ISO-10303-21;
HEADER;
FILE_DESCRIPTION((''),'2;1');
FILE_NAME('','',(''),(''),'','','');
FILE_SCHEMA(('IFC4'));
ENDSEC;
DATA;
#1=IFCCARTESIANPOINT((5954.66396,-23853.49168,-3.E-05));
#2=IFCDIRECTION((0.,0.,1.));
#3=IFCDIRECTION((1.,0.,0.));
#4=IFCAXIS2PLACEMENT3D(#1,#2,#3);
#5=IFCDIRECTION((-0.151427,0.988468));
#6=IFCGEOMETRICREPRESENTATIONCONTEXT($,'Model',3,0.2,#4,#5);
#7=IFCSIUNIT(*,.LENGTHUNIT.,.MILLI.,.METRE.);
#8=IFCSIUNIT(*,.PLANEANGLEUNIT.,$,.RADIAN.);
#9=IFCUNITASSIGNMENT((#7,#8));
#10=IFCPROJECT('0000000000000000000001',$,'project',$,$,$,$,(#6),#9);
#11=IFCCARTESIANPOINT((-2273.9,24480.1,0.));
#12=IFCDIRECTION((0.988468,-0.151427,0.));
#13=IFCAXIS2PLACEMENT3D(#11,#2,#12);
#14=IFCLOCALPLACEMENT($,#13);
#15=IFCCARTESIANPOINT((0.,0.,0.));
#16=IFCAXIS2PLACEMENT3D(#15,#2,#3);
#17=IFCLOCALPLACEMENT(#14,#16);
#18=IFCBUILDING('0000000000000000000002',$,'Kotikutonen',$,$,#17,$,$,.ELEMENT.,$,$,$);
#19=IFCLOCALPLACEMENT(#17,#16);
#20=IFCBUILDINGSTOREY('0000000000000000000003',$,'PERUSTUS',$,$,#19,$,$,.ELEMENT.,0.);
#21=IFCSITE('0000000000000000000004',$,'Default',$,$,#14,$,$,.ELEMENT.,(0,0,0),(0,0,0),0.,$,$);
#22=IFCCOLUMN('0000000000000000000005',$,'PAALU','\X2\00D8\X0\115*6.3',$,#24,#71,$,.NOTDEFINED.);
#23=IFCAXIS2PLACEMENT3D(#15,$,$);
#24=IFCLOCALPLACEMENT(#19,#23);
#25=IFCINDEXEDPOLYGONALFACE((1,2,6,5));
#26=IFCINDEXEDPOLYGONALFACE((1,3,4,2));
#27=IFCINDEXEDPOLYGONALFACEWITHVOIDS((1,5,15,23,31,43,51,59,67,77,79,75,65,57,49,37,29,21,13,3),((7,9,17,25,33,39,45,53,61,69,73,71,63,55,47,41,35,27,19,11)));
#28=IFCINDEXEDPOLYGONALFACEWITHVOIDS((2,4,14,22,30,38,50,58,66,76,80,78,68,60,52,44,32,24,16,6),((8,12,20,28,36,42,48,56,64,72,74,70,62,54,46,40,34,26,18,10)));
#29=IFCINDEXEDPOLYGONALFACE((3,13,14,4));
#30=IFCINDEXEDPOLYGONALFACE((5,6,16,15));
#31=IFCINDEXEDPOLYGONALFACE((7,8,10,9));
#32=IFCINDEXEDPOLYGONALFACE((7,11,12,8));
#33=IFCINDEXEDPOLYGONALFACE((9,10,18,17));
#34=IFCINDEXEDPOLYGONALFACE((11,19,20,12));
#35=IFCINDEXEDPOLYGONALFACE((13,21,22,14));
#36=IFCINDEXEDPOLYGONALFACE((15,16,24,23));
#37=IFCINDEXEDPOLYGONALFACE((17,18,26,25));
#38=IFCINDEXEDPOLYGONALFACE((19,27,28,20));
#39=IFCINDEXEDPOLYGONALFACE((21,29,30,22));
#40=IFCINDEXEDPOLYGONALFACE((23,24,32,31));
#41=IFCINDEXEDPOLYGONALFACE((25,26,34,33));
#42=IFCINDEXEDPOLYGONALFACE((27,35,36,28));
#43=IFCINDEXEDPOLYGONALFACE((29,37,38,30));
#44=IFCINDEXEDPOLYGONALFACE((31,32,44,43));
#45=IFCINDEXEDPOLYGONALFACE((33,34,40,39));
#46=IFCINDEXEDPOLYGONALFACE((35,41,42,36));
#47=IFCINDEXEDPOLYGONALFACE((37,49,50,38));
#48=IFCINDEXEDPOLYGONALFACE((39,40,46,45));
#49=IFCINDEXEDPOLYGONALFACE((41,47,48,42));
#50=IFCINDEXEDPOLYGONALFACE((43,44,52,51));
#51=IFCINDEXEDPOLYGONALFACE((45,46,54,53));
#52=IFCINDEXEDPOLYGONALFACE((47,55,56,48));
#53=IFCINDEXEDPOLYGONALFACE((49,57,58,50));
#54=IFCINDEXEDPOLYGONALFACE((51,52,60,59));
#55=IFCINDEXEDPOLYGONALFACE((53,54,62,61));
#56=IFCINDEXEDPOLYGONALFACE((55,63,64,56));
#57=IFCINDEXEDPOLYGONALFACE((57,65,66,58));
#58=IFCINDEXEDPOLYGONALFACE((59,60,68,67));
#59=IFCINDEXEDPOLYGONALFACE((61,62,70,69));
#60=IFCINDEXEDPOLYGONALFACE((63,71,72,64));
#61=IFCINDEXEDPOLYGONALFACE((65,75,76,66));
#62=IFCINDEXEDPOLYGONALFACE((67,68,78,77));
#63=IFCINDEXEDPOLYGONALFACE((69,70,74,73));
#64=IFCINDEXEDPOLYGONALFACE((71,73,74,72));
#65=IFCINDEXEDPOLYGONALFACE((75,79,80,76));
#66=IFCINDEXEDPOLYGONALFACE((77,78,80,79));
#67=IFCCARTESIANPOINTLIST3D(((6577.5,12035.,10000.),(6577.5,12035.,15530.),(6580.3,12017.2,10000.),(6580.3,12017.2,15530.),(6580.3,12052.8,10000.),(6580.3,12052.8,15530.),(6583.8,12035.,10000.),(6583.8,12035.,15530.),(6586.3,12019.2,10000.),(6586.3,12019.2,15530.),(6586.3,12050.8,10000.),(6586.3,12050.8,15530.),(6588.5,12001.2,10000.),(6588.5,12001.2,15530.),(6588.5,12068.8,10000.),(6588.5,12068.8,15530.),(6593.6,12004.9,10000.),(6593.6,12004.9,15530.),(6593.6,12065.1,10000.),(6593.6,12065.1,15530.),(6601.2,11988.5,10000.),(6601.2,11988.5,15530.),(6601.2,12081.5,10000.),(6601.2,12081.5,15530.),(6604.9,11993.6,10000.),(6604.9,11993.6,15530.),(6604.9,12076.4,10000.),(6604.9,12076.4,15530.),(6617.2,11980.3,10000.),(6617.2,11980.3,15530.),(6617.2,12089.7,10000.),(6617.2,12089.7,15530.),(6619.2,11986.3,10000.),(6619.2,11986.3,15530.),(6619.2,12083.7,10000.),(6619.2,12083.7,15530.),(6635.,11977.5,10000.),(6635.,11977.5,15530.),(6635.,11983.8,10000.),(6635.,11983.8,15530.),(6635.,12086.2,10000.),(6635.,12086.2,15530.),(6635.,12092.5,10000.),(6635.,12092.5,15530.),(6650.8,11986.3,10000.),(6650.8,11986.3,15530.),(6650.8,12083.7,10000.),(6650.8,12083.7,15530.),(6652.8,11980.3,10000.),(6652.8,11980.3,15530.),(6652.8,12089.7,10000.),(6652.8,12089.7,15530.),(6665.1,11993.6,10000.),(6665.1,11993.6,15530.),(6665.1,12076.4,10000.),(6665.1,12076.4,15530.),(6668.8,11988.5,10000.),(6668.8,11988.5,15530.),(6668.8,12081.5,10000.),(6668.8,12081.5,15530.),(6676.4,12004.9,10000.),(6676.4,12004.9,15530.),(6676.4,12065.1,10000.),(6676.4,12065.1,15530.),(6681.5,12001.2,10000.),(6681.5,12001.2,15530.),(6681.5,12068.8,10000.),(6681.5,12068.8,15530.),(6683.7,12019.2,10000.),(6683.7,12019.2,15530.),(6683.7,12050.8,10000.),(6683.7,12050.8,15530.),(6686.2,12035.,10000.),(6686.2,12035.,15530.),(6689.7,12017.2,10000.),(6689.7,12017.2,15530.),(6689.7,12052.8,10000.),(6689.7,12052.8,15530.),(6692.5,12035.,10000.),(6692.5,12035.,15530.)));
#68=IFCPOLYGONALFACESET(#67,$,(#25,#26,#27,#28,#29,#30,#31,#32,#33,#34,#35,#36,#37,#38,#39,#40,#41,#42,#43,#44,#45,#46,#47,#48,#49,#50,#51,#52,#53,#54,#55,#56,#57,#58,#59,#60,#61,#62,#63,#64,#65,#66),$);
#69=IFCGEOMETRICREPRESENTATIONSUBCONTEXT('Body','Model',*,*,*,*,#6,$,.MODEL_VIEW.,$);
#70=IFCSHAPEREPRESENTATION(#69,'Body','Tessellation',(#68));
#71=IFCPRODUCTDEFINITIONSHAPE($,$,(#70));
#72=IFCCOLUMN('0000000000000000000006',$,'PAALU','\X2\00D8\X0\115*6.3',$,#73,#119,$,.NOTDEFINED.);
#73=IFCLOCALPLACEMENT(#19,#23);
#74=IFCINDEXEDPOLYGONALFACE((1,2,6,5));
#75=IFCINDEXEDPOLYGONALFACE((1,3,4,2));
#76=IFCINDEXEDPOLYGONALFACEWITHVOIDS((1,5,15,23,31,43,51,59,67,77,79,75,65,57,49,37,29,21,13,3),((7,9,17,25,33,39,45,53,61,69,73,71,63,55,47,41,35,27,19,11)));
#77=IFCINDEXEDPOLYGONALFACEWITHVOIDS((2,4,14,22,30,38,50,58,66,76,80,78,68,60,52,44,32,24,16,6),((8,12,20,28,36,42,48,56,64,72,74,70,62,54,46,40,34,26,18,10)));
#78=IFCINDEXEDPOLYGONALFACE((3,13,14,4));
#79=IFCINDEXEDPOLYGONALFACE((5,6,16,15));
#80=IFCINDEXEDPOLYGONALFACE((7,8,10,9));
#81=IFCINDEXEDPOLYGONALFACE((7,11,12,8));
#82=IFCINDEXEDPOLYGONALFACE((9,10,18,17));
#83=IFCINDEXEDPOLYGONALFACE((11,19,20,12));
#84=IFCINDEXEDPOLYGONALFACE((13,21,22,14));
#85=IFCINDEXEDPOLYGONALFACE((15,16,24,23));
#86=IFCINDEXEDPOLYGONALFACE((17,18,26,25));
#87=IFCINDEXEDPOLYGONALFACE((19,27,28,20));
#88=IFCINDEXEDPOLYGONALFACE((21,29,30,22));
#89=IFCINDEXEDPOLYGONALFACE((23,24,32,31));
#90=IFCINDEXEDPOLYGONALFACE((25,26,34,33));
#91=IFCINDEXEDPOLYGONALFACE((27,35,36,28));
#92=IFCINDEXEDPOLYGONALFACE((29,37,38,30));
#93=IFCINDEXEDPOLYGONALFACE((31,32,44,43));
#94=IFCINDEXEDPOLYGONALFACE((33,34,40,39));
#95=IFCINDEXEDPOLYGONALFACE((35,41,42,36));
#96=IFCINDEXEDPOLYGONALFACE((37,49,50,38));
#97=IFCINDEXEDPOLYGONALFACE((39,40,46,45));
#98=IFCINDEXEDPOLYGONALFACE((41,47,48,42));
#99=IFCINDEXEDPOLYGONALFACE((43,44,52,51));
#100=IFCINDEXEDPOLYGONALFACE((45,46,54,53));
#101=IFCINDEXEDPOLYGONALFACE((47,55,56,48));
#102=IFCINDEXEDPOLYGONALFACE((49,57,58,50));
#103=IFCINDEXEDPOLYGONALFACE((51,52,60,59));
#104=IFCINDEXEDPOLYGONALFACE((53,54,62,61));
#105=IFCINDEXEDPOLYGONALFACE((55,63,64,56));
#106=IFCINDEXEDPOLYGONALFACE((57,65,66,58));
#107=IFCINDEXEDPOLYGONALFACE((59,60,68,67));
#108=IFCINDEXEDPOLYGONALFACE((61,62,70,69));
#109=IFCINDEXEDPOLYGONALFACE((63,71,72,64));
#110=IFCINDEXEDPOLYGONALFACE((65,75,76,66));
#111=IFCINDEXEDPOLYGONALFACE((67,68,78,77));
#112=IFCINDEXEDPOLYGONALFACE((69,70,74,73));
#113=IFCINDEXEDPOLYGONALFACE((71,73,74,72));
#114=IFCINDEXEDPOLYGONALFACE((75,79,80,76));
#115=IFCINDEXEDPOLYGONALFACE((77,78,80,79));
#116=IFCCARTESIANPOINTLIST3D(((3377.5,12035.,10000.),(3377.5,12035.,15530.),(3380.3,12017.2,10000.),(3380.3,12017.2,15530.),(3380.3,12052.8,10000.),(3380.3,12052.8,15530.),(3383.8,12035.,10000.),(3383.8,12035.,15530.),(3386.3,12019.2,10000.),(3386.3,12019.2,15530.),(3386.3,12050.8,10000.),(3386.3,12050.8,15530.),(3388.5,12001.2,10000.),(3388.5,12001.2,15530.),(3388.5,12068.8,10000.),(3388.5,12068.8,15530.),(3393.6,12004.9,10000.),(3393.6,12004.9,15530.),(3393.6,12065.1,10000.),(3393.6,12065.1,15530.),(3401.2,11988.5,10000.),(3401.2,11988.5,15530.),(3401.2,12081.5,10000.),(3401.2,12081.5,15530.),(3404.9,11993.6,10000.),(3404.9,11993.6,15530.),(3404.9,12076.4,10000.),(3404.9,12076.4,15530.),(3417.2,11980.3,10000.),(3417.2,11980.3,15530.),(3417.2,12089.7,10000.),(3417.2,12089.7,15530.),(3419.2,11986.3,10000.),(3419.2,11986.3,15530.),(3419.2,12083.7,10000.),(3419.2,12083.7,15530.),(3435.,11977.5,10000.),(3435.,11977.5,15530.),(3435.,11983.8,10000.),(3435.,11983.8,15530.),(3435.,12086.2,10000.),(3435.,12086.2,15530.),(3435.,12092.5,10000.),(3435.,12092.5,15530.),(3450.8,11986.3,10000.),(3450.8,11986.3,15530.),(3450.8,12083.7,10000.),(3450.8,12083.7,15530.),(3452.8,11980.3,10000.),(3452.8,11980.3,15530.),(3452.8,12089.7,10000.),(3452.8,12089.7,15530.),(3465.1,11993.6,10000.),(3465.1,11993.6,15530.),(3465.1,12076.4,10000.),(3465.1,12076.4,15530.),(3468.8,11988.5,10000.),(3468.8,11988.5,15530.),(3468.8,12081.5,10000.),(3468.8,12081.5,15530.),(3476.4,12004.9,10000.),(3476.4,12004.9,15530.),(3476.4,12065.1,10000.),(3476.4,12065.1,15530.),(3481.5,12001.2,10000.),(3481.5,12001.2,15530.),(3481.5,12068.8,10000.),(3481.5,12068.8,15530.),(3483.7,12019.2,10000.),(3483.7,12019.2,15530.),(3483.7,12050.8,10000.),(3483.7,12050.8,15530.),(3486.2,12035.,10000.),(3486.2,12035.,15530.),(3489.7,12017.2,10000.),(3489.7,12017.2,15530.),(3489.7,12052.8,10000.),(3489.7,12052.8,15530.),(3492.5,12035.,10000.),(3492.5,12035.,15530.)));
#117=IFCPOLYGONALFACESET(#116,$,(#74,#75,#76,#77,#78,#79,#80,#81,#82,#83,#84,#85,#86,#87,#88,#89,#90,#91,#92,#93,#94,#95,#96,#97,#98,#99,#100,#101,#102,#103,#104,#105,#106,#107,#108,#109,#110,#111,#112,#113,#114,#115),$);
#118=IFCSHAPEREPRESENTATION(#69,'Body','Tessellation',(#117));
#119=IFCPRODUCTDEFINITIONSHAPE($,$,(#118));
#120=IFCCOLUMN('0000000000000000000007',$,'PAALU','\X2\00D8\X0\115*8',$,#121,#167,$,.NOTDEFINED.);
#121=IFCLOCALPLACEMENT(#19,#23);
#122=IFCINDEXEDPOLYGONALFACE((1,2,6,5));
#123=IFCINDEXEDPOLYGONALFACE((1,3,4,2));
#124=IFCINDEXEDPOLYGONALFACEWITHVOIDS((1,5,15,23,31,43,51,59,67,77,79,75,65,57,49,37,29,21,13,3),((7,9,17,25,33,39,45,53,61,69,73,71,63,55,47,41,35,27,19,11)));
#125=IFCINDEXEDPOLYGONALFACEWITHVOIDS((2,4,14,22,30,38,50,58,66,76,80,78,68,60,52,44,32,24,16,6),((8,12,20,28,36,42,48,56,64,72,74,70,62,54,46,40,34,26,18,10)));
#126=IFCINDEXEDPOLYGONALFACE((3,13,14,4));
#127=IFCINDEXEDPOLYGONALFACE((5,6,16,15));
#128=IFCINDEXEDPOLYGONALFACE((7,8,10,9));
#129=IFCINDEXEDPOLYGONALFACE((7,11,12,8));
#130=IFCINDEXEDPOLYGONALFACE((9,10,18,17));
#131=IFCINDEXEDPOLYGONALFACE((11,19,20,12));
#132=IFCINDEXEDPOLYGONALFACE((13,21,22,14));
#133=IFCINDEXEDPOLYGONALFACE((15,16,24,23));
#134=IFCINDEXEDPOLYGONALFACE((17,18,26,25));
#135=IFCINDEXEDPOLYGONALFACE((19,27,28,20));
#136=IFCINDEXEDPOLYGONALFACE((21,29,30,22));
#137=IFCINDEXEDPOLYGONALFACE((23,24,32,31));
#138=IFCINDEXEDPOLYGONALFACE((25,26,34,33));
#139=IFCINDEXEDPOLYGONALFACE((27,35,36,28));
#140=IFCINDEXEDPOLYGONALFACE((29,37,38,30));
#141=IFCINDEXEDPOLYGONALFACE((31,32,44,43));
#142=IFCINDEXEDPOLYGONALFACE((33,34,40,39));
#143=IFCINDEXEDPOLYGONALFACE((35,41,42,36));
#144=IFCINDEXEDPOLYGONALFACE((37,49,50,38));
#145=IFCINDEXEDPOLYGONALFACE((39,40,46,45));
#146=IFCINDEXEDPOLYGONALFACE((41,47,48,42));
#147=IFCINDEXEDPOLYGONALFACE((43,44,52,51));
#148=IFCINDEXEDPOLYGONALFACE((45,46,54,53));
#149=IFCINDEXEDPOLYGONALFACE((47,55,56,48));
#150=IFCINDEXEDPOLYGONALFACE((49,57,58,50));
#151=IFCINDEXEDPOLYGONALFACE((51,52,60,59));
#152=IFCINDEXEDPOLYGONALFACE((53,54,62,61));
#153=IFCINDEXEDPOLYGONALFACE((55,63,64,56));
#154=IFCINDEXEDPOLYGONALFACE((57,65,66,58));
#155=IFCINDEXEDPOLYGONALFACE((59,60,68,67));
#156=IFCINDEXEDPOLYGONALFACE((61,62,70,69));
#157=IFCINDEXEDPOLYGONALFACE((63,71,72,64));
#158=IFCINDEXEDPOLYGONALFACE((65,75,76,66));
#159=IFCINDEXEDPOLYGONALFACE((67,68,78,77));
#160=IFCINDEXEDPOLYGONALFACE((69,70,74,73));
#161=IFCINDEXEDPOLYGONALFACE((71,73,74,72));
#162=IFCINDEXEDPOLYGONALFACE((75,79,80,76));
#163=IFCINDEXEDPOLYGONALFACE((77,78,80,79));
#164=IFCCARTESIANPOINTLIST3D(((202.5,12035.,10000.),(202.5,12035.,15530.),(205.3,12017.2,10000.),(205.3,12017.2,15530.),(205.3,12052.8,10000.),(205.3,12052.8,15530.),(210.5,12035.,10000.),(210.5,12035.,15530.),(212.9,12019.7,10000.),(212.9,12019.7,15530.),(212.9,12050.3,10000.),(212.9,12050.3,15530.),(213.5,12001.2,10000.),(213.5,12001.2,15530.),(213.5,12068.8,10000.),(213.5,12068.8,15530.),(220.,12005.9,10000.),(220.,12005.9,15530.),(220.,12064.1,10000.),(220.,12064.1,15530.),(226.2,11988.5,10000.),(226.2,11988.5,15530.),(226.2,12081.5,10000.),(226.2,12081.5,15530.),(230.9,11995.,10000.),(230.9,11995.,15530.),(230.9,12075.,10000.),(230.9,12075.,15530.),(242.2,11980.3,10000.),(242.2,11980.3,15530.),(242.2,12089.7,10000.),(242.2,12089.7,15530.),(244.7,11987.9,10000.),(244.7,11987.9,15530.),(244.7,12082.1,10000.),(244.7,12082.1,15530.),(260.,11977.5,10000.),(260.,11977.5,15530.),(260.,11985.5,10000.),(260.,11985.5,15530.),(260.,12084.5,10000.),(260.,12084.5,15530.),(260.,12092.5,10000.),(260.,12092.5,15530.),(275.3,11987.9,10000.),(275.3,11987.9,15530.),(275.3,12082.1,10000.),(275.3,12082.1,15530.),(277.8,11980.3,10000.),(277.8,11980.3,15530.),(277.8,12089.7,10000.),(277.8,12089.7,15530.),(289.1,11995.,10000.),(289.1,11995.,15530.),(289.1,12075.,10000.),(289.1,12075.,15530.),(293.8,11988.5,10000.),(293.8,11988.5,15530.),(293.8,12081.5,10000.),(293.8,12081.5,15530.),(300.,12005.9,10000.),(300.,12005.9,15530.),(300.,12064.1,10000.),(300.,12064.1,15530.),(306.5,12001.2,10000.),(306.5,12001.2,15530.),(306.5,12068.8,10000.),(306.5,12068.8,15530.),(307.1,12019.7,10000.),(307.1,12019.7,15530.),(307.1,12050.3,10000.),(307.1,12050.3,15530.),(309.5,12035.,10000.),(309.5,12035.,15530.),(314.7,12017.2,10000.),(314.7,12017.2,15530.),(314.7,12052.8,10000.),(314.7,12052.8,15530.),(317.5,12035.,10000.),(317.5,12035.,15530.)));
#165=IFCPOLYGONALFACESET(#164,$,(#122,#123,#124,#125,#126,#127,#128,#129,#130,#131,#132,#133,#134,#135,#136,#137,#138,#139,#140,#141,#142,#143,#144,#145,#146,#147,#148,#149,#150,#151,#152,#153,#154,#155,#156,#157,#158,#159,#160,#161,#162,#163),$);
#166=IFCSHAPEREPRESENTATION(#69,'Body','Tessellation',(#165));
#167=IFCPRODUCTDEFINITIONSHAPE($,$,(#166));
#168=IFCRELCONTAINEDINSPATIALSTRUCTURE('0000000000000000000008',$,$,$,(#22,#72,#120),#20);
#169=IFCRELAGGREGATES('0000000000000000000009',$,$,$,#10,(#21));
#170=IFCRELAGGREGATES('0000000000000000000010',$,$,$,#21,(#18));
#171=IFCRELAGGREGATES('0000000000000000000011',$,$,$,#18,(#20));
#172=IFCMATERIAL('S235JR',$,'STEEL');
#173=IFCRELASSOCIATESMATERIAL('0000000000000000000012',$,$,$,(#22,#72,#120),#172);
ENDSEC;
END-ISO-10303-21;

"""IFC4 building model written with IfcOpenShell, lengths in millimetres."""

from ifc_helpers import new_model, si_unit, direction, frame, origin_with_axes, place, context, subcontext, project, spatial, line, indexed_curve, outline, extrude, material, element, save


model = new_model("IFC4")

# Units and contexts
model_context = context("Model", 3, precision=0.2, world=frame((5954.66396, -23853.49168, -3e-05), z_axis=(0.0, 0.0, 1.0), x_axis=(1.0, 0.0, 0.0)), true_north=direction((-0.151427, 0.988468)))
body_context = subcontext(model_context, "Body", "Model", "MODEL_VIEW")
ifc_project = project(units=[si_unit("LENGTHUNIT", "METRE", prefix="MILLI"), si_unit("PLANEANGLEUNIT", "RADIAN")], contexts=[model_context])

# Site, building, storey
site_placement = place(None, frame((-2273.9, 24480.1, 0.0), z_axis=(0.0, 0.0, 1.0), x_axis=(0.988468, -0.151427, 0.0)))
site = spatial("IfcSite", under=ifc_project, at=site_placement, Name="Default", CompositionType="ELEMENT", RefLatitude=(0, 0, 0), RefLongitude=(0, 0, 0), RefElevation=0.0)
building_placement = place(site_placement, origin_with_axes())
building = spatial("IfcBuilding", under=site, at=building_placement, Name="Kotikutonen", CompositionType="ELEMENT")
storey_placement = place(building_placement, origin_with_axes())
storey = spatial("IfcBuildingStorey", under=building, at=storey_placement, Name="PERUSTUS", CompositionType="ELEMENT", Elevation=0.0)

# Columns
ifc_material = material(Name="S235JR", Category="STEEL")
for number, where, z_axis, x_axis, name in (
    (1, (6635.0, 12035.0, 10000.0), (-1.0, 0.0, 0.0), (0.0, 0.0, 1.0), "PAALU"),
    (2, (3435.0, 12035.0, 10000.0), (-1.0, 0.0, 0.0), (0.0, 0.0, 1.0), "PAALU"),
):
    element("IfcColumn", number, at=place(storey_placement, frame(where, z_axis=z_axis, x_axis=x_axis)), inside=storey, material=ifc_material, Name=name, Description="Ø115*6.3", PredefinedType="NOTDEFINED", context=body_context, shape_type="SolidModel", body=[
        extrude(outline(indexed_curve([(57.5, 0.0), (54.7, 17.8), (46.5, 33.8), (33.8, 46.5), (17.8, 54.7), (0.0, 57.5), (-17.8, 54.7), (-33.8, 46.5), (-46.5, 33.8), (-54.7, 17.8), (-57.5, 0.0), (-54.7, -17.8), (-46.5, -33.8), (-33.8, -46.5), (-17.8, -54.7), (0.0, -57.5), (17.8, -54.7), (33.8, -46.5), (46.5, -33.8), (54.7, -17.8)], segments=[line(1, 2, 3, 4, 5, 6, 7, 8, 9, 10, 11, 12, 13, 14, 15, 16, 17, 18, 19, 20, 1)]), holes=[indexed_curve([(51.2, 0.0), (48.7, -15.8), (41.4, -30.1), (30.1, -41.4), (15.8, -48.7), (0.0, -51.2), (-15.8, -48.7), (-30.1, -41.4), (-41.4, -30.1), (-48.7, -15.8), (-51.2, 0.0), (-48.7, 15.8), (-41.4, 30.1), (-30.1, 41.4), (-15.8, 48.7), (0.0, 51.2), (15.8, 48.7), (30.1, 41.4), (41.4, 30.1), (48.7, 15.8)], segments=[line(1, 2, 3, 4, 5, 6, 7, 8, 9, 10, 11, 12, 13, 14, 15, 16, 17, 18, 19, 20, 1)])]), frame((0.0, 0.0, 0.0), z_axis=(-1.0, 0.0, 0.0), x_axis=(0.0, 0.0, 1.0)), (0.0, 0.0, -1.0), 5530.0),
    ])
for number, where, z_axis, x_axis, name in (
    (3, (260.0, 12035.0, 10000.0), (-1.0, 0.0, 0.0), (0.0, 0.0, 1.0), "PAALU"),
):
    element("IfcColumn", number, at=place(storey_placement, frame(where, z_axis=z_axis, x_axis=x_axis)), inside=storey, material=ifc_material, Name=name, Description="Ø115*8", PredefinedType="NOTDEFINED", context=body_context, shape_type="SolidModel", body=[
        extrude(outline(indexed_curve([(57.5, 0.0), (54.7, 17.8), (46.5, 33.8), (33.8, 46.5), (17.8, 54.7), (0.0, 57.5), (-17.8, 54.7), (-33.8, 46.5), (-46.5, 33.8), (-54.7, 17.8), (-57.5, 0.0), (-54.7, -17.8), (-46.5, -33.8), (-33.8, -46.5), (-17.8, -54.7), (0.0, -57.5), (17.8, -54.7), (33.8, -46.5), (46.5, -33.8), (54.7, -17.8)], segments=[line(1, 2, 3, 4, 5, 6, 7, 8, 9, 10, 11, 12, 13, 14, 15, 16, 17, 18, 19, 20, 1)]), holes=[indexed_curve([(49.5, 0.0), (47.1, -15.3), (40.0, -29.1), (29.1, -40.0), (15.3, -47.1), (0.0, -49.5), (-15.3, -47.1), (-29.1, -40.0), (-40.0, -29.1), (-47.1, -15.3), (-49.5, 0.0), (-47.1, 15.3), (-40.0, 29.1), (-29.1, 40.0), (-15.3, 47.1), (0.0, 49.5), (15.3, 47.1), (29.1, 40.0), (40.0, 29.1), (47.1, 15.3)], segments=[line(1, 2, 3, 4, 5, 6, 7, 8, 9, 10, 11, 12, 13, 14, 15, 16, 17, 18, 19, 20, 1)])]), frame((0.0, 0.0, 0.0), z_axis=(-1.0, 0.0, 0.0), x_axis=(0.0, 0.0, 1.0)), (0.0, 0.0, -1.0), 5530.0),
    ])

save(model, "model.ifc")
